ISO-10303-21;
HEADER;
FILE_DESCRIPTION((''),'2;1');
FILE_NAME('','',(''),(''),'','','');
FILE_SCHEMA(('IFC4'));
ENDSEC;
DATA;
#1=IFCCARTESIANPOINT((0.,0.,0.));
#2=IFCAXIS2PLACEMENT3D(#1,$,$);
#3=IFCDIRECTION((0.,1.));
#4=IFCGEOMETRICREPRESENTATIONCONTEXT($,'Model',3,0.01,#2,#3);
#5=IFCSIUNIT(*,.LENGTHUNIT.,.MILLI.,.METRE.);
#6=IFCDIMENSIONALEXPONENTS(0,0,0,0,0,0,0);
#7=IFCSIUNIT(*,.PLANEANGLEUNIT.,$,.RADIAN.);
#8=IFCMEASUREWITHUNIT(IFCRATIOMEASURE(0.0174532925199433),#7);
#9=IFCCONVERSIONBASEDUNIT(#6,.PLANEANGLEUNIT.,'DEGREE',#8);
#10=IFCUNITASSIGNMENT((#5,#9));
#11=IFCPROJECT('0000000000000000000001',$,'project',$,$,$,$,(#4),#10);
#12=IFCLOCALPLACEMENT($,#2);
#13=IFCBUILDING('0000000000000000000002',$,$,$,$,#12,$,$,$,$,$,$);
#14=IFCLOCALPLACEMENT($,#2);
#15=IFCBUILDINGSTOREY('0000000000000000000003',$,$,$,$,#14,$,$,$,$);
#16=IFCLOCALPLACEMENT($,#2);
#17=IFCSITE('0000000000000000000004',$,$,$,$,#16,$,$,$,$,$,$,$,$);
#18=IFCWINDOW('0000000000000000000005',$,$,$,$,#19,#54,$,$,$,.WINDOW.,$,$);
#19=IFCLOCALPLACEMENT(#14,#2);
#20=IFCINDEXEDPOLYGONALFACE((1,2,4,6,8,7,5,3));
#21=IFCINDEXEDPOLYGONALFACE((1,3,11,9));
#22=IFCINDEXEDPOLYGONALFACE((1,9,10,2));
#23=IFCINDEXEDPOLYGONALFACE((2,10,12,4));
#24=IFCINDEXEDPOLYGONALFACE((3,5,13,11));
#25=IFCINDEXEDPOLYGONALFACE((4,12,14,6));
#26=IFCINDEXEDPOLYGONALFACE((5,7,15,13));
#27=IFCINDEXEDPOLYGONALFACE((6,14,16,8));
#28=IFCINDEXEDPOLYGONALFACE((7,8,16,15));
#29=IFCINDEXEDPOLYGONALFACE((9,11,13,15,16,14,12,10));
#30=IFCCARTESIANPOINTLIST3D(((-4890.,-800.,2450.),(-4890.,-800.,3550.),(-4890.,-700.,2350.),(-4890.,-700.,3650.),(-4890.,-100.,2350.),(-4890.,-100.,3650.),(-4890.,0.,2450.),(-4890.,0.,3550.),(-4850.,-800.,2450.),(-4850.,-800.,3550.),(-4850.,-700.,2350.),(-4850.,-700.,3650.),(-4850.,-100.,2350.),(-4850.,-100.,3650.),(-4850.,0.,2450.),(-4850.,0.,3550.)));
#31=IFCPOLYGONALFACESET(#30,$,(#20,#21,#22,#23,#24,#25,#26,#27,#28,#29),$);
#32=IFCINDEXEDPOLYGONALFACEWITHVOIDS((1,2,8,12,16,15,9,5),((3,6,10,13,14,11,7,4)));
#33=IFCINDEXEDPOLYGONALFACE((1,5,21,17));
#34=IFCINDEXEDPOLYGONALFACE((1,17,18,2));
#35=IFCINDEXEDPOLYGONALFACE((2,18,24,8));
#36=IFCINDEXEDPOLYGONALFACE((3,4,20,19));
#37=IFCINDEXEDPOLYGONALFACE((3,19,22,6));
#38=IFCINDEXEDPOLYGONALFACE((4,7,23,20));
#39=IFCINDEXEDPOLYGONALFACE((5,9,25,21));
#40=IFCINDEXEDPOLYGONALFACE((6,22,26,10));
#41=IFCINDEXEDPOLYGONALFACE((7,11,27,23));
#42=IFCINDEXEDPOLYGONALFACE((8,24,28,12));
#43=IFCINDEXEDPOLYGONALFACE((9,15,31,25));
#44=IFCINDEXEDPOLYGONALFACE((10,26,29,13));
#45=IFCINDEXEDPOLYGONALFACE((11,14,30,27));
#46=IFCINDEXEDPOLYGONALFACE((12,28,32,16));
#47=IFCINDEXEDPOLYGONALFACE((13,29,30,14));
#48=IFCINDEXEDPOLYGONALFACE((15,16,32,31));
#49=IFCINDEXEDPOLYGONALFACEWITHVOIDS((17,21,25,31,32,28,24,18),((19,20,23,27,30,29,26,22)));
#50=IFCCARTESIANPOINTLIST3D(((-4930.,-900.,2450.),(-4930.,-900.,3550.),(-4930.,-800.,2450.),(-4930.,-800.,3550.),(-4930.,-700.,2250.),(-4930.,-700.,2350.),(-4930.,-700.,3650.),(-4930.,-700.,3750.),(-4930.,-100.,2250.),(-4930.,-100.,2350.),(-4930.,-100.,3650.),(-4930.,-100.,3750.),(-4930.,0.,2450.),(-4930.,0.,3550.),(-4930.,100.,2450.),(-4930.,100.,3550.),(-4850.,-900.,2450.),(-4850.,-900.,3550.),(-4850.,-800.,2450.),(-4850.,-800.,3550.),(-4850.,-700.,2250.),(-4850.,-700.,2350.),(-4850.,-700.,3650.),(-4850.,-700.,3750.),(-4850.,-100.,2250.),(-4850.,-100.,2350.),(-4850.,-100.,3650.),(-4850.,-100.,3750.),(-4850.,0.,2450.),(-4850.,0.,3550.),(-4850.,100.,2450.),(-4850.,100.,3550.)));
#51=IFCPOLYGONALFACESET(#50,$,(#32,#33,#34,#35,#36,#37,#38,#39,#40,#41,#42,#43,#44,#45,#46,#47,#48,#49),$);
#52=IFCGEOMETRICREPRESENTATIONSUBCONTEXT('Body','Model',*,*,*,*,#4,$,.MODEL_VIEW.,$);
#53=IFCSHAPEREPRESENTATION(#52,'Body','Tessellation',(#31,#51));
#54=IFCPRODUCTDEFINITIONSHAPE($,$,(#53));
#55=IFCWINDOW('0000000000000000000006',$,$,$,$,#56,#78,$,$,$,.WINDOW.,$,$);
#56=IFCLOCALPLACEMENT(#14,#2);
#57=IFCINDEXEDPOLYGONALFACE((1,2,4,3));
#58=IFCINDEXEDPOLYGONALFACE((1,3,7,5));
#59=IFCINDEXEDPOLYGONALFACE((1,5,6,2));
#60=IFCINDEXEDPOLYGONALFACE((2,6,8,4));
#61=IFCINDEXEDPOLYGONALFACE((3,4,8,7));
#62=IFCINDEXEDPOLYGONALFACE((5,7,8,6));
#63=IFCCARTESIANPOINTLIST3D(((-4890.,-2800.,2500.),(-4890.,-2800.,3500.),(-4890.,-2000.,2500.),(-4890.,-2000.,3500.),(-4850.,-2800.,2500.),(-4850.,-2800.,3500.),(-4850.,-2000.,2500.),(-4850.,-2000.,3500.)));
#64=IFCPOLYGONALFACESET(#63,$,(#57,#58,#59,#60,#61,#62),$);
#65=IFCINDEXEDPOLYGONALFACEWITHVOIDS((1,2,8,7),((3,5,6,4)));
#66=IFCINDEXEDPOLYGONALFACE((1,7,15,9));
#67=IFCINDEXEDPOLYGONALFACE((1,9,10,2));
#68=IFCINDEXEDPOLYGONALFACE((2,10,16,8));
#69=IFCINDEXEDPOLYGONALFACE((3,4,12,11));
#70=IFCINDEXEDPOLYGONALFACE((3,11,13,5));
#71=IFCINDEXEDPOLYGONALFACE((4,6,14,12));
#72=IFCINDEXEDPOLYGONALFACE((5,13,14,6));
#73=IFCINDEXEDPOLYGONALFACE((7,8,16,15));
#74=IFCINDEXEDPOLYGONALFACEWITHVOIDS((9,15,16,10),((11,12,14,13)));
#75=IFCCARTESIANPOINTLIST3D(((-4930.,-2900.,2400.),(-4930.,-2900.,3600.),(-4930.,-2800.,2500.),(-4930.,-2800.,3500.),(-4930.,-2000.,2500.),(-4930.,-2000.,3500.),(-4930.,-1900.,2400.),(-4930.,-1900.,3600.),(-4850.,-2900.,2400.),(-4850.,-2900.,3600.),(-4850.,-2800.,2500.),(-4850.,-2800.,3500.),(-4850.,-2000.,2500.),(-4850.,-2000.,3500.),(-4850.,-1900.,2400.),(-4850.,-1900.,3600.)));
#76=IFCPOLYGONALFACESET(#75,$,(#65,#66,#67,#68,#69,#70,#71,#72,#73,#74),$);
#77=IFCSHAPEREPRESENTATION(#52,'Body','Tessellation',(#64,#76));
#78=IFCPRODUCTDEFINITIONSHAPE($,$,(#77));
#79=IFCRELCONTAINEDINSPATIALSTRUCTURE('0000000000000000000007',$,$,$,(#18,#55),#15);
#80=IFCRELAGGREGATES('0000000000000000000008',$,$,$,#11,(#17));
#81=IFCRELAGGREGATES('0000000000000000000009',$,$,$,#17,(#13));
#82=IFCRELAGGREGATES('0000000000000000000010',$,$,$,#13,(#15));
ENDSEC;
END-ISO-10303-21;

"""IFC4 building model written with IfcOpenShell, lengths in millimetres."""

from ifc_helpers import new_model, entity, si_unit, converted_unit, direction, frame, origin, place, context, subcontext, project, spatial, element, save


model = new_model("IFC4")

# Units and contexts
model_context = context("Model", 3, precision=0.01, world=origin(), true_north=direction((0.0, 1.0)))
body_context = subcontext(model_context, "Body", "Model", "MODEL_VIEW")
ifc_project = project(units=[si_unit("LENGTHUNIT", "METRE", prefix="MILLI"), converted_unit("PLANEANGLEUNIT", "DEGREE", entity("IfcRatioMeasure", 0.0174532925199433), si_unit("PLANEANGLEUNIT", "RADIAN"), dimensions=[0, 0, 0, 0, 0, 0, 0])], contexts=[model_context])

# Site, building, storey
site_placement = place(None, origin())
site = spatial("IfcSite", under=ifc_project, at=site_placement)
building_placement = place(None, origin())
building = spatial("IfcBuilding", under=site, at=building_placement)
storey_placement = place(None, origin())
storey = spatial("IfcBuildingStorey", under=building, at=storey_placement)

# Shared definitions
cartesian_point_1 = entity("IfcCartesianPoint", [-400.0, -550.0])
shared_polyline_1 = entity("IfcPolyline", [cartesian_point_1, entity("IfcCartesianPoint", [-400.0, 550.0]), entity("IfcCartesianPoint", [-300.0, 650.0]), entity("IfcCartesianPoint", [300.0, 650.0]), entity("IfcCartesianPoint", [400.0, 550.0]), entity("IfcCartesianPoint", [400.0, -550.0]), entity("IfcCartesianPoint", [300.0, -650.0]), entity("IfcCartesianPoint", [-300.0, -650.0]), cartesian_point_1])
cartesian_point_2 = entity("IfcCartesianPoint", [-400.0, -500.0])
shared_polyline_2 = entity("IfcPolyline", [cartesian_point_2, entity("IfcCartesianPoint", [-400.0, 500.0]), entity("IfcCartesianPoint", [-400.0, 500.0]), entity("IfcCartesianPoint", [400.0, 500.0]), entity("IfcCartesianPoint", [400.0, 500.0]), entity("IfcCartesianPoint", [400.0, -500.0]), entity("IfcCartesianPoint", [400.0, -500.0]), entity("IfcCartesianPoint", [-400.0, -500.0]), cartesian_point_2])

# Shared definitions
wall_1_placement = place(storey_placement, frame((-4900.0, 100.0, 0.0), z_axis=(0.0, 0.0, 1.0), x_axis=(0.0, -1.0, 0.0)))
window_1_placement = place(wall_1_placement, frame((500.0, 50.0, 3000.0)))
window_2_placement = place(wall_1_placement, frame((2500.0, 50.0, 3000.0)))

# Windows
cartesian_point_3 = entity("IfcCartesianPoint", [-500.0, -550.0])
element("IfcWindow", 1, at=window_1_placement, inside=storey, PredefinedType="WINDOW", context=body_context, shape_type="SweptSolid", body=[
    entity("IfcExtrudedAreaSolid", entity("IfcArbitraryClosedProfileDef", "AREA", None, shared_polyline_1), entity("IfcAxis2Placement3D", entity("IfcCartesianPoint", [0.0, 0.0, 0.0]), entity("IfcDirection", [0.0, -1.0, 0.0]), entity("IfcDirection", [1.0, 0.0, 0.0])), entity("IfcDirection", [0.0, 0.0, 1.0]), 40.0),
    entity("IfcExtrudedAreaSolid", entity("IfcArbitraryProfileDefWithVoids", "AREA", None, entity("IfcPolyline", [cartesian_point_3, entity("IfcCartesianPoint", [-500.0, 550.0]), entity("IfcCartesianPoint", [-300.0, 750.0]), entity("IfcCartesianPoint", [300.0, 750.0]), entity("IfcCartesianPoint", [500.0, 550.0]), entity("IfcCartesianPoint", [500.0, -550.0]), entity("IfcCartesianPoint", [300.0, -750.0]), entity("IfcCartesianPoint", [-300.0, -750.0]), cartesian_point_3]), [shared_polyline_1]), entity("IfcAxis2Placement3D", entity("IfcCartesianPoint", [0.0, 0.0, 0.0]), entity("IfcDirection", [0.0, -1.0, 0.0]), entity("IfcDirection", [1.0, 0.0, 0.0])), entity("IfcDirection", [0.0, 0.0, 1.0]), 80.0),
])
cartesian_point_4 = entity("IfcCartesianPoint", [-500.0, -600.0])
element("IfcWindow", 2, at=window_2_placement, inside=storey, PredefinedType="WINDOW", context=body_context, shape_type="SweptSolid", body=[
    entity("IfcExtrudedAreaSolid", entity("IfcArbitraryClosedProfileDef", "AREA", None, shared_polyline_2), entity("IfcAxis2Placement3D", entity("IfcCartesianPoint", [0.0, 0.0, 0.0]), entity("IfcDirection", [0.0, -1.0, 0.0]), entity("IfcDirection", [1.0, 0.0, 0.0])), entity("IfcDirection", [0.0, 0.0, 1.0]), 40.0),
    entity("IfcExtrudedAreaSolid", entity("IfcArbitraryProfileDefWithVoids", "AREA", None, entity("IfcPolyline", [cartesian_point_4, entity("IfcCartesianPoint", [-500.0, 600.0]), entity("IfcCartesianPoint", [-500.0, 600.0]), entity("IfcCartesianPoint", [500.0, 600.0]), entity("IfcCartesianPoint", [500.0, 600.0]), entity("IfcCartesianPoint", [500.0, -600.0]), entity("IfcCartesianPoint", [500.0, -600.0]), entity("IfcCartesianPoint", [-500.0, -600.0]), cartesian_point_4]), [shared_polyline_2]), entity("IfcAxis2Placement3D", entity("IfcCartesianPoint", [0.0, 0.0, 0.0]), entity("IfcDirection", [0.0, -1.0, 0.0]), entity("IfcDirection", [1.0, 0.0, 0.0])), entity("IfcDirection", [0.0, 0.0, 1.0]), 80.0),
])

save(model, "model.ifc")
